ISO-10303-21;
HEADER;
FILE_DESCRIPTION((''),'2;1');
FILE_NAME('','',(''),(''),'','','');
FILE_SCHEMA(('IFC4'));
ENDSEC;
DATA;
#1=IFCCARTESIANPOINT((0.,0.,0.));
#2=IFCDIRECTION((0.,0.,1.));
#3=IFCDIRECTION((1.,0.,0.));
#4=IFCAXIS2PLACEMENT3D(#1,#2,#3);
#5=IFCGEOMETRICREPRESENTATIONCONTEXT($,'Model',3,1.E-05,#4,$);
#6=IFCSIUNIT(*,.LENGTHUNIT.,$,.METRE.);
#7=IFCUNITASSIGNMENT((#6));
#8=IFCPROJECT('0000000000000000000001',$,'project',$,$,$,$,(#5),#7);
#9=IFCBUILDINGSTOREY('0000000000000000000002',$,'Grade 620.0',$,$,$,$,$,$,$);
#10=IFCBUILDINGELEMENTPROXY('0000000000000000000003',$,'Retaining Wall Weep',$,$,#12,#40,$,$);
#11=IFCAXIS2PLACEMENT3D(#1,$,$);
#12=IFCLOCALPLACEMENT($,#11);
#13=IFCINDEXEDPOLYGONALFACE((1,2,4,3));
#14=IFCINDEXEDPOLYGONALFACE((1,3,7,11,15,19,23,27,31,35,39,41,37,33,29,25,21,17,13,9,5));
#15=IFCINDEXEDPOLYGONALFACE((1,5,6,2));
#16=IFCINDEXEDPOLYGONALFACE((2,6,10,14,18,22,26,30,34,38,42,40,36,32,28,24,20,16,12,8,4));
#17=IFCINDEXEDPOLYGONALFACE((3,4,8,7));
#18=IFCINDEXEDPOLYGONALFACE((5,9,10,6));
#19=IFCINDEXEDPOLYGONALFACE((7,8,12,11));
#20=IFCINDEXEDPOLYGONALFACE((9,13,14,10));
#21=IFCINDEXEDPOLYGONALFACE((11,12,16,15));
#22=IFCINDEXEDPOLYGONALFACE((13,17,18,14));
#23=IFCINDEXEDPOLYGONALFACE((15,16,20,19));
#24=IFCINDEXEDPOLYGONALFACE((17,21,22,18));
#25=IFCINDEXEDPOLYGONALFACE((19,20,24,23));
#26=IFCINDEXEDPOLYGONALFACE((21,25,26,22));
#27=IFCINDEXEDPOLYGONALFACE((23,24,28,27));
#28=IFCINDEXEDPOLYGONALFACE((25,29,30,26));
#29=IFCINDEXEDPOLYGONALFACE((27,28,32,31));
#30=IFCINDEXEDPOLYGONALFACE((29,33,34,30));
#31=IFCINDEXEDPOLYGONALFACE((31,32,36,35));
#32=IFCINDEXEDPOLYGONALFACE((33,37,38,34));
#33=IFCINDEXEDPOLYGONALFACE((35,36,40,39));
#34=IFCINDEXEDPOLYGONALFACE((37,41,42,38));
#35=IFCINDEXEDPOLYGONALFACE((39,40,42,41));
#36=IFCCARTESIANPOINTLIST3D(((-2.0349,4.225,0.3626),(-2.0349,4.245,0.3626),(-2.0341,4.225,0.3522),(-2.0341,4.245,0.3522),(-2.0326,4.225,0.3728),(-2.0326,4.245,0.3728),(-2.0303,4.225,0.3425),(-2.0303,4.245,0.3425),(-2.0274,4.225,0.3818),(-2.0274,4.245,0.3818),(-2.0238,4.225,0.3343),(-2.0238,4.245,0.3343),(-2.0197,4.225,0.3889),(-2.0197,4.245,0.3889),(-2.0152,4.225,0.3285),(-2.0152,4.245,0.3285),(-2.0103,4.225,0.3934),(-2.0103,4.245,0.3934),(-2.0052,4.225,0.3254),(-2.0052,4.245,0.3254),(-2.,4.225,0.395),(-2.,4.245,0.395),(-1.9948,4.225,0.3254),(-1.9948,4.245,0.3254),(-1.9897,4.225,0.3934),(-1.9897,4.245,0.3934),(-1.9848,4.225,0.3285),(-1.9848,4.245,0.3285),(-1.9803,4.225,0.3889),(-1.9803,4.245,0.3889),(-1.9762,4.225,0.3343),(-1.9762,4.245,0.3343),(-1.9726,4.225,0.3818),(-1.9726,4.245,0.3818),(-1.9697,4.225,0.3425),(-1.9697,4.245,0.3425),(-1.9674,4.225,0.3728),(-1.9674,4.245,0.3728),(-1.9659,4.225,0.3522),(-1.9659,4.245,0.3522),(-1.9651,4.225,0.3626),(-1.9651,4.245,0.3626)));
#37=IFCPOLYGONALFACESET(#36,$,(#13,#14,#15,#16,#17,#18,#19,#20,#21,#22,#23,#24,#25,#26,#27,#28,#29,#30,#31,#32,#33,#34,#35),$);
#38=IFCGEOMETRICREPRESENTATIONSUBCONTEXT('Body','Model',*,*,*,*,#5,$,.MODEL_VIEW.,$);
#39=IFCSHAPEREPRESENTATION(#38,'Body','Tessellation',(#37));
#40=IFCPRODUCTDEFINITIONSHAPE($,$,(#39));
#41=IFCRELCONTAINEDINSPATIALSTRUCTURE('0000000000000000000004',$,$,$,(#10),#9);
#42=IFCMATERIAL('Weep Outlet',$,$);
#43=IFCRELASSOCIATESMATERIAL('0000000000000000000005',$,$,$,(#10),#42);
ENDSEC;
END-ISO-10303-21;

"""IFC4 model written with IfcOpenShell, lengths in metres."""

from ifc_helpers import new_model, si_unit, frame, origin_with_axes, place, context, subcontext, project, spatial, circle, extrude, material, element, save


model = new_model("IFC4")

# Units and contexts
model_context = context("Model", 3, precision=1e-05, world=origin_with_axes())
body_context = subcontext(model_context, "Body", "Model", "MODEL_VIEW")
ifc_project = project(units=[si_unit("LENGTHUNIT", "METRE")], contexts=[model_context])

# Storey
storey = spatial("IfcBuildingStorey", Name="Grade 620.0")

# Building element proxy
ifc_material_1 = material(Name="Weep Outlet")
for number, where, z_axis, x_axis, name in (
    (1, (-2.0, 4.225, 0.36), (0.0, 1.0, 0.0), (0.0, 0.0, 1.0), "Retaining Wall Weep"),
):
    element("IfcBuildingElementProxy", number, at=place(None, frame(where, z_axis=z_axis, x_axis=x_axis)), inside=storey, material=ifc_material_1, Name=name, context=body_context, shape_type="SweptSolid", body=[
        extrude(circle(Radius=0.035), origin_with_axes(), (0.0, 0.0, 1.0), 0.02),
    ])

save(model, "model.ifc")
